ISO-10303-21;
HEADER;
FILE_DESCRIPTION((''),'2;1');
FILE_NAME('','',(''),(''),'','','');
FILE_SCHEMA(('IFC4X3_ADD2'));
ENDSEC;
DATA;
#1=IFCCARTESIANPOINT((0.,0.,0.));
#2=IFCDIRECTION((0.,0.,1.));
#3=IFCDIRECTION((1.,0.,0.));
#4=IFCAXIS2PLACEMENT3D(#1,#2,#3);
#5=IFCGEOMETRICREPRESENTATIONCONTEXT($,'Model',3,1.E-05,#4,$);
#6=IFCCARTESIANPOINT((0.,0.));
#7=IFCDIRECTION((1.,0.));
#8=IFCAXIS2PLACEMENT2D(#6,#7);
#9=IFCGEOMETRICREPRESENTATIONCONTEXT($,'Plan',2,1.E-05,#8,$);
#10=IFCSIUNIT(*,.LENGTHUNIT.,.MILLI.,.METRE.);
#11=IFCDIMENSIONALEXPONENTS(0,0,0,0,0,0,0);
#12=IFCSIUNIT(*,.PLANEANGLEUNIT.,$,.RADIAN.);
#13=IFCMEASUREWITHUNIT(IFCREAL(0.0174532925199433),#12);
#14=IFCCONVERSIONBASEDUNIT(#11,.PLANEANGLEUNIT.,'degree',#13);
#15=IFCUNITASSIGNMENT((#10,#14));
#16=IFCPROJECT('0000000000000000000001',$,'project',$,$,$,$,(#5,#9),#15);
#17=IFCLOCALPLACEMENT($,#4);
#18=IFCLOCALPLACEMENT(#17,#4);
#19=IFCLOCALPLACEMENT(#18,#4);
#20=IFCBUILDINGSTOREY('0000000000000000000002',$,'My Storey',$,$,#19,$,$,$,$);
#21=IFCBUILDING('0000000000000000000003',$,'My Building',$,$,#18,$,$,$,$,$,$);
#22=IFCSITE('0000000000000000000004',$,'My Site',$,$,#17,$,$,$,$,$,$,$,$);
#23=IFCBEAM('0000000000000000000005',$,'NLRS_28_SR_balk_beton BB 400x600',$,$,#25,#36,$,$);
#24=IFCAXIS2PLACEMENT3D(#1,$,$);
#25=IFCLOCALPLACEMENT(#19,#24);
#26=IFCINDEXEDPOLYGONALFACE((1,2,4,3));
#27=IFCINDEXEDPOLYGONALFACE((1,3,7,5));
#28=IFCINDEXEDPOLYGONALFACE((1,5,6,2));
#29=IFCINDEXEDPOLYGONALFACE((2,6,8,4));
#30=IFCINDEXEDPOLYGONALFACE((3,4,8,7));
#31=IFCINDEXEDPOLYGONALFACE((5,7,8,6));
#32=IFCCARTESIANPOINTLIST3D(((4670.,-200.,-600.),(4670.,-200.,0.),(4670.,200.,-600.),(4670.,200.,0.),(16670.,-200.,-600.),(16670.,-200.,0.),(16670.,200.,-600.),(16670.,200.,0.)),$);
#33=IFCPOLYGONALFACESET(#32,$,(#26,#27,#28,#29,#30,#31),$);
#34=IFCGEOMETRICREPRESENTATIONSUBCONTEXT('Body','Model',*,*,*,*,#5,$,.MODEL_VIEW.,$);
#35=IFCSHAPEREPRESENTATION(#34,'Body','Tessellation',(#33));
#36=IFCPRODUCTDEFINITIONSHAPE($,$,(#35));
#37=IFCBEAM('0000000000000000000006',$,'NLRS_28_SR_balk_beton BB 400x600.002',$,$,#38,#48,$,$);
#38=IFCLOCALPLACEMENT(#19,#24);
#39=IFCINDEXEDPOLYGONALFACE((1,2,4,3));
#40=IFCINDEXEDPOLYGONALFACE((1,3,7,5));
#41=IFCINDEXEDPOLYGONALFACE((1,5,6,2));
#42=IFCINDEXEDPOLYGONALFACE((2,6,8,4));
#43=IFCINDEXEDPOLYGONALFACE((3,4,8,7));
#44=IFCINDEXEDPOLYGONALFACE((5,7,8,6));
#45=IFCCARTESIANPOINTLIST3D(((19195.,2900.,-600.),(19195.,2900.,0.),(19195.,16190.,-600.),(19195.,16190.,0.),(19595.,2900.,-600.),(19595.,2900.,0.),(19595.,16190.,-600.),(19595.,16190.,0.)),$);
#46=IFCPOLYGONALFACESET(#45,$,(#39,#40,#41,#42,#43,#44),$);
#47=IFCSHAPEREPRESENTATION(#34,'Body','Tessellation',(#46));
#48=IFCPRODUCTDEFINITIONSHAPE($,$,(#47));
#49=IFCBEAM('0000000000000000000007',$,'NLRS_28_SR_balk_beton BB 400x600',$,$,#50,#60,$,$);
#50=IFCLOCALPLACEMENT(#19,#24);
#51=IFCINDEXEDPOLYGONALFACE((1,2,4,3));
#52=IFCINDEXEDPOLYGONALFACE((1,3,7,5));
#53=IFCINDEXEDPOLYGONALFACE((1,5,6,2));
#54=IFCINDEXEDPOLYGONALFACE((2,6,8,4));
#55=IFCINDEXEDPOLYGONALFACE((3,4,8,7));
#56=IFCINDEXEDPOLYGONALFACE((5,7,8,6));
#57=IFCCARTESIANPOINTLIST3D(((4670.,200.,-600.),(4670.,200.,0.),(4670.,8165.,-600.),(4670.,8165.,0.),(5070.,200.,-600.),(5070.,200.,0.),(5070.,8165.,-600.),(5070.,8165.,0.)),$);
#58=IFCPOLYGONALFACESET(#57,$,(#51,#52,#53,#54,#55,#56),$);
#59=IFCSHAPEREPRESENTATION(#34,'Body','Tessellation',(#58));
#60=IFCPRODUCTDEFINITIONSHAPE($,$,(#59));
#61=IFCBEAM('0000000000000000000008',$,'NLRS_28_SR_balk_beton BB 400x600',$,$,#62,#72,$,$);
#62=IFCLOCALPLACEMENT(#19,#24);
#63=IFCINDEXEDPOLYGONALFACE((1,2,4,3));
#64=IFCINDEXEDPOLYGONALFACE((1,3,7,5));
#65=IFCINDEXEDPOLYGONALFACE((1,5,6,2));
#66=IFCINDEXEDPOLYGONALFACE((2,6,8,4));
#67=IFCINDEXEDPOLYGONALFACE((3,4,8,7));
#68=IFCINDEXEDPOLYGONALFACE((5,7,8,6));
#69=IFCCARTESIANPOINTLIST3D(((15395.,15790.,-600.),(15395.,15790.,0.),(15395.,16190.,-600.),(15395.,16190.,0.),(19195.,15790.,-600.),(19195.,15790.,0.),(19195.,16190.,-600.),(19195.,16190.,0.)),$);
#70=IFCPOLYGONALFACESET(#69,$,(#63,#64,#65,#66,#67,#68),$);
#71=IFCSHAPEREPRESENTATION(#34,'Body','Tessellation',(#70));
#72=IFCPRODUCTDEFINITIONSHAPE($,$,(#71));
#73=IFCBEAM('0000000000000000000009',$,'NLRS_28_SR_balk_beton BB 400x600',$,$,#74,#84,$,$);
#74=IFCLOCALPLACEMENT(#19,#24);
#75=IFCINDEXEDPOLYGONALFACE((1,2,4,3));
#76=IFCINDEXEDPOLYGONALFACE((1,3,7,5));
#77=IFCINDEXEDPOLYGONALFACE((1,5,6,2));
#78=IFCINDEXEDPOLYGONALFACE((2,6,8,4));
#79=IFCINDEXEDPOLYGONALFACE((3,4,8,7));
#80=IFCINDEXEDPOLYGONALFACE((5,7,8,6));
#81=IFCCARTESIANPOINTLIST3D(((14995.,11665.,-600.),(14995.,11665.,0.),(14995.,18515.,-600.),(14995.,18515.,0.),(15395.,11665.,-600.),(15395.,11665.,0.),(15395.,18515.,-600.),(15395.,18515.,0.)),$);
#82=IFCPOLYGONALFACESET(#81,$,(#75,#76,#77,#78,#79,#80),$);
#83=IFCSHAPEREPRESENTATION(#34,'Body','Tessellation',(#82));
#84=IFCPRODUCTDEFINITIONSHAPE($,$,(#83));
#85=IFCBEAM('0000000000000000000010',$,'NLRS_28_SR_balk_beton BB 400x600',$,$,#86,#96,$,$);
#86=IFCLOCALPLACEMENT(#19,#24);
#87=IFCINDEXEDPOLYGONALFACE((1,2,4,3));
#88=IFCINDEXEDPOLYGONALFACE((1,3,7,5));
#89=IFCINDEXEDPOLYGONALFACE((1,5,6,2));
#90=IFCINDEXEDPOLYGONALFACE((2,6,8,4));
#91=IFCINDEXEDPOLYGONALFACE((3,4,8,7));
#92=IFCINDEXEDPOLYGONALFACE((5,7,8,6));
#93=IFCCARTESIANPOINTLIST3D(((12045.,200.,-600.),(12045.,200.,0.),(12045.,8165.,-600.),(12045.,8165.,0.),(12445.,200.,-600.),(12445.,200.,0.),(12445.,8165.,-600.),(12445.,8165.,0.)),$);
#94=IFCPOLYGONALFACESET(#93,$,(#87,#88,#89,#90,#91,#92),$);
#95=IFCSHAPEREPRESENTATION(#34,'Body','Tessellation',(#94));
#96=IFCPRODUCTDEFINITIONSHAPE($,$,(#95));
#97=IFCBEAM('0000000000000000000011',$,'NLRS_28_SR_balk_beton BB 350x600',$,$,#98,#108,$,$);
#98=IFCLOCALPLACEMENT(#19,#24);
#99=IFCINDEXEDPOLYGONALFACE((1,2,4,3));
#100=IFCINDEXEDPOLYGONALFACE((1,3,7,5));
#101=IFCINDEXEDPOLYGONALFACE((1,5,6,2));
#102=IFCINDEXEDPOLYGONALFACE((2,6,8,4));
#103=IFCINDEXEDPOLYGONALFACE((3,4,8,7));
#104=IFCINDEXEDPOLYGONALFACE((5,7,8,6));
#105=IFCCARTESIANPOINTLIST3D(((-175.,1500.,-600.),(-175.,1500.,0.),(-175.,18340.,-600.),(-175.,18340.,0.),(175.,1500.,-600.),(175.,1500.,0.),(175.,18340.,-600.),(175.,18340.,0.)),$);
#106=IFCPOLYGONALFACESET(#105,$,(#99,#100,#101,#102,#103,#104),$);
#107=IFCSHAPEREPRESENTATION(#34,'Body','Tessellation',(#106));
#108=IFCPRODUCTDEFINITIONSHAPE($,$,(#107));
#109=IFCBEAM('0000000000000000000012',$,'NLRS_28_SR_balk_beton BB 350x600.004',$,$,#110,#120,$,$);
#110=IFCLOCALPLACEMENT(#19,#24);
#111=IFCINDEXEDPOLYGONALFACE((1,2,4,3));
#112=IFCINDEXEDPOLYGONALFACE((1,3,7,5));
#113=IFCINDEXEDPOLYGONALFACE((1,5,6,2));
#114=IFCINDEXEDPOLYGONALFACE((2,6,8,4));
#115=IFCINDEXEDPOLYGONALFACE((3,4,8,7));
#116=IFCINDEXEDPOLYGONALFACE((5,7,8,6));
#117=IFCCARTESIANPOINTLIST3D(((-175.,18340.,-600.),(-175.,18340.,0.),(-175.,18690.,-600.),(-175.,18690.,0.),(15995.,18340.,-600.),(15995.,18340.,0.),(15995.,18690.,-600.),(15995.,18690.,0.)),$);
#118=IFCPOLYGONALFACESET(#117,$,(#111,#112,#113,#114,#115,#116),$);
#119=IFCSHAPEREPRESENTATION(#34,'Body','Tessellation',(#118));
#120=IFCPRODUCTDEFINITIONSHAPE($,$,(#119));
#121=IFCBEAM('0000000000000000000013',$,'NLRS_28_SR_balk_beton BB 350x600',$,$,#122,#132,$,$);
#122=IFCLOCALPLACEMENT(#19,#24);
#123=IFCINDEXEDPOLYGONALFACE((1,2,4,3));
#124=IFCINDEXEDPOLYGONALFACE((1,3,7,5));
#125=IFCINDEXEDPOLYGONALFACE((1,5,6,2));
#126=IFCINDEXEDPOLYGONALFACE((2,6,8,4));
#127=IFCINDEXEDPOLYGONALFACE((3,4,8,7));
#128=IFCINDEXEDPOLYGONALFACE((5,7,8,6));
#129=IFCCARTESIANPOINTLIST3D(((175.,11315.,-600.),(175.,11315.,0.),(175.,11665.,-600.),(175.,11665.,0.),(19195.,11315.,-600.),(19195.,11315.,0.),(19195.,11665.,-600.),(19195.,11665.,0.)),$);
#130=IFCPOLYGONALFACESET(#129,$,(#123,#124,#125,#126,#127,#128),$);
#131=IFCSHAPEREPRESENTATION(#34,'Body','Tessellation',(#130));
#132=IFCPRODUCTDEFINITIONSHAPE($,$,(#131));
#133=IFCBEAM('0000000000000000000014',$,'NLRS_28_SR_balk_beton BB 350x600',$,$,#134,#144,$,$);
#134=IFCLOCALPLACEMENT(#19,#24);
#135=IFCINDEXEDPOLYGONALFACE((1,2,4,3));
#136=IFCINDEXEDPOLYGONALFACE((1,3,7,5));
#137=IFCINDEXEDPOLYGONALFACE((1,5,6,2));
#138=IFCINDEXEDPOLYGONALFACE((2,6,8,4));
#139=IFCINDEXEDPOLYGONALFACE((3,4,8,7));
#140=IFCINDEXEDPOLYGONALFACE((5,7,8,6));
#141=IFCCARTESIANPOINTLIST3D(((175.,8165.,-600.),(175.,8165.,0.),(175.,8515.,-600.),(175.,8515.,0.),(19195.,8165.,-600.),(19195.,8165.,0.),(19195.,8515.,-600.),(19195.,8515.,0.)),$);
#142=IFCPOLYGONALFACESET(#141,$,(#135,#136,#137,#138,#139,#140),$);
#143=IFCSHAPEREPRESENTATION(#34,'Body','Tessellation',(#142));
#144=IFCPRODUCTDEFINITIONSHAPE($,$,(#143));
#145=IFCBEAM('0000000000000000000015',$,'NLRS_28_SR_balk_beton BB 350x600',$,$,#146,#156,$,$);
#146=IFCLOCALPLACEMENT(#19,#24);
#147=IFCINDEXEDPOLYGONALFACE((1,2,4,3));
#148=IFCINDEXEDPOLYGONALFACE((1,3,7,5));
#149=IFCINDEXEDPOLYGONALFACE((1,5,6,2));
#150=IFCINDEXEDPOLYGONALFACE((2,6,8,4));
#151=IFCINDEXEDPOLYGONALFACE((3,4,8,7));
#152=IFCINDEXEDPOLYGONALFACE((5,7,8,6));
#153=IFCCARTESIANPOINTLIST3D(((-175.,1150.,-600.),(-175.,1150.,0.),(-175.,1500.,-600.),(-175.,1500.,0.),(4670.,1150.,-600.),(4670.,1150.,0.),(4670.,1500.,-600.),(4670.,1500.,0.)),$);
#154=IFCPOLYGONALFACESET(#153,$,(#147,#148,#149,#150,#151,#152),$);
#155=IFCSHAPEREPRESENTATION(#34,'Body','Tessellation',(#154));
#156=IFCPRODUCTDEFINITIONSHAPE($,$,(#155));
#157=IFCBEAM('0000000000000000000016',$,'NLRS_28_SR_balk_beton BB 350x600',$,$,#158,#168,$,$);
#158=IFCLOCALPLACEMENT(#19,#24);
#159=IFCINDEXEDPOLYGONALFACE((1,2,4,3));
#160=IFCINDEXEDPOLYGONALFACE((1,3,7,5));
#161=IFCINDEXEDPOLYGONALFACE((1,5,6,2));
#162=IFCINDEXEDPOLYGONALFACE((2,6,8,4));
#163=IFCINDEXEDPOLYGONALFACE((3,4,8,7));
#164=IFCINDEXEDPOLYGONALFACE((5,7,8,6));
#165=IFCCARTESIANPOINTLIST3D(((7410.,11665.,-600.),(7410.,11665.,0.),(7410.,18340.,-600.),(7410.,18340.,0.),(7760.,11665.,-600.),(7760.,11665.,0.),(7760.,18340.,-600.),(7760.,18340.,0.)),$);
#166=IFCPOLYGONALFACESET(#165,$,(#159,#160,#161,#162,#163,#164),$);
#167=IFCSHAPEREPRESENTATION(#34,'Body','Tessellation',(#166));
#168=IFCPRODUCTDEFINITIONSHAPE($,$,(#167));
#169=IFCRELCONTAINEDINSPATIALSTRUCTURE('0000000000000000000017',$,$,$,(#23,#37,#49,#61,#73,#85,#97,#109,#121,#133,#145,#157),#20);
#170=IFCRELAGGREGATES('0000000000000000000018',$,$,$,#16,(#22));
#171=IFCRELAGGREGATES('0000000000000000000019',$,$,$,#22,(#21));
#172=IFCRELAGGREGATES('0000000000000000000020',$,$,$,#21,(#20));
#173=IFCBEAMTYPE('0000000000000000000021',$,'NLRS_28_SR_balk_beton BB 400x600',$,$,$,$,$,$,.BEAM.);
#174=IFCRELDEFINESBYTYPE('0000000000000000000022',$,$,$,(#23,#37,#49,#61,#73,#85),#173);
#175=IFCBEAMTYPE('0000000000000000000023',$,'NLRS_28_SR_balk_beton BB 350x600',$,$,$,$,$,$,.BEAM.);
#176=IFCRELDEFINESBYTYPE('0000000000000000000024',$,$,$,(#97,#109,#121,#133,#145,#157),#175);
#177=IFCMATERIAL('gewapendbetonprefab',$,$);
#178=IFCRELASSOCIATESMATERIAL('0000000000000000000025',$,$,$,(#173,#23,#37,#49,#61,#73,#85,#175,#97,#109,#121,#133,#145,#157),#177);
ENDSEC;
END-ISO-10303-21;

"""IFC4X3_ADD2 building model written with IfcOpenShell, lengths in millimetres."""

from ifc_helpers import new_model, entity, si_unit, converted_unit, frame, origin_with_axes, origin_2d_with_axis, place, context, subcontext, project, spatial, rectangle, extrude, material, material_profile, profile_set, profile_usage, type_object, element, save


model = new_model("IFC4X3_ADD2")

# Units and contexts
model_context = context("Model", 3, precision=1e-05, world=origin_with_axes())
plan_context = context("Plan", 2, precision=1e-05, world=origin_2d_with_axis())
body_context = subcontext(model_context, "Body", "Model", "MODEL_VIEW")
ifc_project = project(units=[si_unit("LENGTHUNIT", "METRE", prefix="MILLI"), converted_unit("PLANEANGLEUNIT", "degree", entity("IfcReal", 0.0174532925199433), si_unit("PLANEANGLEUNIT", "RADIAN"), dimensions=[0, 0, 0, 0, 0, 0, 0])], contexts=[model_context, plan_context])

# Site, building, storey
site_placement = place(None, origin_with_axes())
site = spatial("IfcSite", under=ifc_project, at=site_placement, Name="My Site")
building_placement = place(site_placement, origin_with_axes())
building = spatial("IfcBuilding", under=site, at=building_placement, Name="My Building")
storey_placement = place(building_placement, origin_with_axes())
storey = spatial("IfcBuildingStorey", under=building, at=storey_placement, Name="My Storey")

# Beams
ifc_material = material(Name="gewapendbetonprefab")
ifc_material_profile_1 = material_profile(ifc_material, rectangle(XDim=400.0, YDim=600.0))
ifc_profile_set_1 = profile_set([ifc_material_profile_1], Name="NLRS_28_SR_balk_beton BB 400x600")
ifc_profile_usage_1 = profile_usage(ifc_profile_set_1, cardinal=8)
beam_type_1 = type_object("IfcBeamType", Name="NLRS_28_SR_balk_beton BB 400x600", PredefinedType="BEAM", material=ifc_profile_set_1)
beam_1_placement = place(storey_placement, frame((4670.0, 0.0, 0.0), z_axis=(1.0, 0.0, 0.0), x_axis=(0.0, 1.0, 0.0)))
element("IfcBeam", 1, at=beam_1_placement, inside=storey, type_object=beam_type_1, material=ifc_profile_usage_1, Name="NLRS_28_SR_balk_beton BB 400x600", context=body_context, shape_type="SweptSolid", body=[
    extrude(rectangle(XDim=400.0, YDim=600.0), frame((0.0, -300.0, 0.0), z_axis=(0.0, 0.0, 1.0), x_axis=(1.0, 0.0, 0.0)), (0.0, 0.0, 1.0), 12000.0),
])
ifc_profile_usage_2 = profile_usage(ifc_profile_set_1, cardinal=8)
beam_2_placement = place(storey_placement, frame((19395.0, 2900.0, 0.0), z_axis=(0.0, 1.0, 0.0), x_axis=(-1.0, 0.0, 0.0)))
element("IfcBeam", 2, at=beam_2_placement, inside=storey, type_object=beam_type_1, material=ifc_profile_usage_2, Name="NLRS_28_SR_balk_beton BB 400x600.002", context=body_context, shape_type="SweptSolid", body=[
    extrude(rectangle(XDim=400.0, YDim=600.0), frame((0.0, -300.0, 0.0), z_axis=(0.0, 0.0, 1.0), x_axis=(1.0, 0.0, 0.0)), (0.0, 0.0, 1.0), 13290.0),
])
ifc_profile_usage_3 = profile_usage(ifc_profile_set_1, cardinal=8)
beam_3_placement = place(storey_placement, frame((4870.0, 200.0, 0.0), z_axis=(0.0, 1.0, 0.0), x_axis=(-1.0, 0.0, 0.0)))
element("IfcBeam", 3, at=beam_3_placement, inside=storey, type_object=beam_type_1, material=ifc_profile_usage_3, Name="NLRS_28_SR_balk_beton BB 400x600", context=body_context, shape_type="SweptSolid", body=[
    extrude(rectangle(XDim=400.0, YDim=600.0), frame((0.0, -300.0, 0.0), z_axis=(0.0, 0.0, 1.0), x_axis=(1.0, 0.0, 0.0)), (0.0, 0.0, 1.0), 7965.0),
])
ifc_profile_usage_4 = profile_usage(ifc_profile_set_1, cardinal=8)
beam_4_placement = place(storey_placement, frame((19195.0, 15990.0, 0.0), z_axis=(-1.0, 0.0, 0.0), x_axis=(0.0, -1.0, 0.0)))
element("IfcBeam", 4, at=beam_4_placement, inside=storey, type_object=beam_type_1, material=ifc_profile_usage_4, Name="NLRS_28_SR_balk_beton BB 400x600", context=body_context, shape_type="SweptSolid", body=[
    extrude(rectangle(XDim=400.0, YDim=600.0), frame((0.0, -300.0, 0.0), z_axis=(0.0, 0.0, 1.0), x_axis=(1.0, 0.0, 0.0)), (0.0, 0.0, 1.0), 3800.0),
])
ifc_profile_usage_5 = profile_usage(ifc_profile_set_1, cardinal=8)
beam_5_placement = place(storey_placement, frame((15195.0, 11665.0, 0.0), z_axis=(0.0, 1.0, 0.0), x_axis=(-1.0, 0.0, 0.0)))
element("IfcBeam", 5, at=beam_5_placement, inside=storey, type_object=beam_type_1, material=ifc_profile_usage_5, Name="NLRS_28_SR_balk_beton BB 400x600", context=body_context, shape_type="SweptSolid", body=[
    extrude(rectangle(XDim=400.0, YDim=600.0), frame((0.0, -300.0, 0.0), z_axis=(0.0, 0.0, 1.0), x_axis=(1.0, 0.0, 0.0)), (0.0, 0.0, 1.0), 6850.0),
])
ifc_profile_usage_6 = profile_usage(ifc_profile_set_1, cardinal=8)
beam_6_placement = place(storey_placement, frame((12245.0, 200.0, 0.0), z_axis=(0.0, 1.0, 0.0), x_axis=(-1.0, 0.0, 0.0)))
element("IfcBeam", 6, at=beam_6_placement, inside=storey, type_object=beam_type_1, material=ifc_profile_usage_6, Name="NLRS_28_SR_balk_beton BB 400x600", context=body_context, shape_type="SweptSolid", body=[
    extrude(rectangle(XDim=400.0, YDim=600.0), frame((0.0, -300.0, 0.0), z_axis=(0.0, 0.0, 1.0), x_axis=(1.0, 0.0, 0.0)), (0.0, 0.0, 1.0), 7965.0),
])
ifc_material_profile_2 = material_profile(ifc_material, rectangle(XDim=350.0, YDim=600.0))
ifc_profile_set_2 = profile_set([ifc_material_profile_2], Name="NLRS_28_SR_balk_beton BB 350x600")
ifc_profile_usage_7 = profile_usage(ifc_profile_set_2, cardinal=8)
beam_type_2 = type_object("IfcBeamType", Name="NLRS_28_SR_balk_beton BB 350x600", PredefinedType="BEAM", material=ifc_profile_set_2)
beam_7_placement = place(storey_placement, frame((0.0, 1500.0, 0.0), z_axis=(0.0, 1.0, 0.0), x_axis=(-1.0, 0.0, 0.0)))
element("IfcBeam", 7, at=beam_7_placement, inside=storey, type_object=beam_type_2, material=ifc_profile_usage_7, Name="NLRS_28_SR_balk_beton BB 350x600", context=body_context, shape_type="SweptSolid", body=[
    extrude(rectangle(XDim=350.0, YDim=600.0), frame((0.0, -300.0, 0.0), z_axis=(0.0, 0.0, 1.0), x_axis=(1.0, 0.0, 0.0)), (0.0, 0.0, 1.0), 16840.0),
])
ifc_profile_usage_8 = profile_usage(ifc_profile_set_2, cardinal=8)
beam_8_placement = place(storey_placement, frame((-175.0, 18515.0, 0.0), z_axis=(1.0, 0.0, 0.0), x_axis=(0.0, 1.0, 0.0)))
element("IfcBeam", 8, at=beam_8_placement, inside=storey, type_object=beam_type_2, material=ifc_profile_usage_8, Name="NLRS_28_SR_balk_beton BB 350x600.004", context=body_context, shape_type="SweptSolid", body=[
    extrude(rectangle(XDim=350.0, YDim=600.0), frame((0.0, -300.0, 0.0)), (0.0, 0.0, 1.0), 16170.0),
])
ifc_profile_usage_9 = profile_usage(ifc_profile_set_2, cardinal=8)
beam_9_placement = place(storey_placement, frame((19195.0, 11490.0, 0.0), z_axis=(-1.0, 0.0, 0.0), x_axis=(0.0, -1.0, 0.0)))
element("IfcBeam", 9, at=beam_9_placement, inside=storey, type_object=beam_type_2, material=ifc_profile_usage_9, Name="NLRS_28_SR_balk_beton BB 350x600", context=body_context, shape_type="SweptSolid", body=[
    extrude(rectangle(XDim=350.0, YDim=600.0), frame((0.0, -300.0, 0.0), z_axis=(0.0, 0.0, 1.0), x_axis=(1.0, 0.0, 0.0)), (0.0, 0.0, 1.0), 19020.0),
])
ifc_profile_usage_10 = profile_usage(ifc_profile_set_2, cardinal=8)
beam_10_placement = place(storey_placement, frame((19195.0, 8340.0, 0.0), z_axis=(-1.0, 0.0, 0.0), x_axis=(0.0, -1.0, 0.0)))
element("IfcBeam", 10, at=beam_10_placement, inside=storey, type_object=beam_type_2, material=ifc_profile_usage_10, Name="NLRS_28_SR_balk_beton BB 350x600", context=body_context, shape_type="SweptSolid", body=[
    extrude(rectangle(XDim=350.0, YDim=600.0), frame((0.0, -300.0, 0.0), z_axis=(0.0, 0.0, 1.0), x_axis=(1.0, 0.0, 0.0)), (0.0, 0.0, 1.0), 19020.0),
])
ifc_profile_usage_11 = profile_usage(ifc_profile_set_2, cardinal=8)
beam_11_placement = place(storey_placement, frame((4670.0, 1325.0, 0.0), z_axis=(-1.0, 0.0, 0.0), x_axis=(0.0, -1.0, 0.0)))
element("IfcBeam", 11, at=beam_11_placement, inside=storey, type_object=beam_type_2, material=ifc_profile_usage_11, Name="NLRS_28_SR_balk_beton BB 350x600", context=body_context, shape_type="SweptSolid", body=[
    extrude(rectangle(XDim=350.0, YDim=600.0), frame((0.0, -300.0, 0.0), z_axis=(0.0, 0.0, 1.0), x_axis=(1.0, 0.0, 0.0)), (0.0, 0.0, 1.0), 4845.0),
])
ifc_profile_usage_12 = profile_usage(ifc_profile_set_2, cardinal=8)
beam_12_placement = place(storey_placement, frame((7585.0, 11665.0, 0.0), z_axis=(0.0, 1.0, 0.0), x_axis=(-1.0, 0.0, 0.0)))
element("IfcBeam", 12, at=beam_12_placement, inside=storey, type_object=beam_type_2, material=ifc_profile_usage_12, Name="NLRS_28_SR_balk_beton BB 350x600", context=body_context, shape_type="SweptSolid", body=[
    extrude(rectangle(XDim=350.0, YDim=600.0), frame((0.0, -300.0, 0.0), z_axis=(0.0, 0.0, 1.0), x_axis=(1.0, 0.0, 0.0)), (0.0, 0.0, 1.0), 6675.0),
])

save(model, "model.ifc")
